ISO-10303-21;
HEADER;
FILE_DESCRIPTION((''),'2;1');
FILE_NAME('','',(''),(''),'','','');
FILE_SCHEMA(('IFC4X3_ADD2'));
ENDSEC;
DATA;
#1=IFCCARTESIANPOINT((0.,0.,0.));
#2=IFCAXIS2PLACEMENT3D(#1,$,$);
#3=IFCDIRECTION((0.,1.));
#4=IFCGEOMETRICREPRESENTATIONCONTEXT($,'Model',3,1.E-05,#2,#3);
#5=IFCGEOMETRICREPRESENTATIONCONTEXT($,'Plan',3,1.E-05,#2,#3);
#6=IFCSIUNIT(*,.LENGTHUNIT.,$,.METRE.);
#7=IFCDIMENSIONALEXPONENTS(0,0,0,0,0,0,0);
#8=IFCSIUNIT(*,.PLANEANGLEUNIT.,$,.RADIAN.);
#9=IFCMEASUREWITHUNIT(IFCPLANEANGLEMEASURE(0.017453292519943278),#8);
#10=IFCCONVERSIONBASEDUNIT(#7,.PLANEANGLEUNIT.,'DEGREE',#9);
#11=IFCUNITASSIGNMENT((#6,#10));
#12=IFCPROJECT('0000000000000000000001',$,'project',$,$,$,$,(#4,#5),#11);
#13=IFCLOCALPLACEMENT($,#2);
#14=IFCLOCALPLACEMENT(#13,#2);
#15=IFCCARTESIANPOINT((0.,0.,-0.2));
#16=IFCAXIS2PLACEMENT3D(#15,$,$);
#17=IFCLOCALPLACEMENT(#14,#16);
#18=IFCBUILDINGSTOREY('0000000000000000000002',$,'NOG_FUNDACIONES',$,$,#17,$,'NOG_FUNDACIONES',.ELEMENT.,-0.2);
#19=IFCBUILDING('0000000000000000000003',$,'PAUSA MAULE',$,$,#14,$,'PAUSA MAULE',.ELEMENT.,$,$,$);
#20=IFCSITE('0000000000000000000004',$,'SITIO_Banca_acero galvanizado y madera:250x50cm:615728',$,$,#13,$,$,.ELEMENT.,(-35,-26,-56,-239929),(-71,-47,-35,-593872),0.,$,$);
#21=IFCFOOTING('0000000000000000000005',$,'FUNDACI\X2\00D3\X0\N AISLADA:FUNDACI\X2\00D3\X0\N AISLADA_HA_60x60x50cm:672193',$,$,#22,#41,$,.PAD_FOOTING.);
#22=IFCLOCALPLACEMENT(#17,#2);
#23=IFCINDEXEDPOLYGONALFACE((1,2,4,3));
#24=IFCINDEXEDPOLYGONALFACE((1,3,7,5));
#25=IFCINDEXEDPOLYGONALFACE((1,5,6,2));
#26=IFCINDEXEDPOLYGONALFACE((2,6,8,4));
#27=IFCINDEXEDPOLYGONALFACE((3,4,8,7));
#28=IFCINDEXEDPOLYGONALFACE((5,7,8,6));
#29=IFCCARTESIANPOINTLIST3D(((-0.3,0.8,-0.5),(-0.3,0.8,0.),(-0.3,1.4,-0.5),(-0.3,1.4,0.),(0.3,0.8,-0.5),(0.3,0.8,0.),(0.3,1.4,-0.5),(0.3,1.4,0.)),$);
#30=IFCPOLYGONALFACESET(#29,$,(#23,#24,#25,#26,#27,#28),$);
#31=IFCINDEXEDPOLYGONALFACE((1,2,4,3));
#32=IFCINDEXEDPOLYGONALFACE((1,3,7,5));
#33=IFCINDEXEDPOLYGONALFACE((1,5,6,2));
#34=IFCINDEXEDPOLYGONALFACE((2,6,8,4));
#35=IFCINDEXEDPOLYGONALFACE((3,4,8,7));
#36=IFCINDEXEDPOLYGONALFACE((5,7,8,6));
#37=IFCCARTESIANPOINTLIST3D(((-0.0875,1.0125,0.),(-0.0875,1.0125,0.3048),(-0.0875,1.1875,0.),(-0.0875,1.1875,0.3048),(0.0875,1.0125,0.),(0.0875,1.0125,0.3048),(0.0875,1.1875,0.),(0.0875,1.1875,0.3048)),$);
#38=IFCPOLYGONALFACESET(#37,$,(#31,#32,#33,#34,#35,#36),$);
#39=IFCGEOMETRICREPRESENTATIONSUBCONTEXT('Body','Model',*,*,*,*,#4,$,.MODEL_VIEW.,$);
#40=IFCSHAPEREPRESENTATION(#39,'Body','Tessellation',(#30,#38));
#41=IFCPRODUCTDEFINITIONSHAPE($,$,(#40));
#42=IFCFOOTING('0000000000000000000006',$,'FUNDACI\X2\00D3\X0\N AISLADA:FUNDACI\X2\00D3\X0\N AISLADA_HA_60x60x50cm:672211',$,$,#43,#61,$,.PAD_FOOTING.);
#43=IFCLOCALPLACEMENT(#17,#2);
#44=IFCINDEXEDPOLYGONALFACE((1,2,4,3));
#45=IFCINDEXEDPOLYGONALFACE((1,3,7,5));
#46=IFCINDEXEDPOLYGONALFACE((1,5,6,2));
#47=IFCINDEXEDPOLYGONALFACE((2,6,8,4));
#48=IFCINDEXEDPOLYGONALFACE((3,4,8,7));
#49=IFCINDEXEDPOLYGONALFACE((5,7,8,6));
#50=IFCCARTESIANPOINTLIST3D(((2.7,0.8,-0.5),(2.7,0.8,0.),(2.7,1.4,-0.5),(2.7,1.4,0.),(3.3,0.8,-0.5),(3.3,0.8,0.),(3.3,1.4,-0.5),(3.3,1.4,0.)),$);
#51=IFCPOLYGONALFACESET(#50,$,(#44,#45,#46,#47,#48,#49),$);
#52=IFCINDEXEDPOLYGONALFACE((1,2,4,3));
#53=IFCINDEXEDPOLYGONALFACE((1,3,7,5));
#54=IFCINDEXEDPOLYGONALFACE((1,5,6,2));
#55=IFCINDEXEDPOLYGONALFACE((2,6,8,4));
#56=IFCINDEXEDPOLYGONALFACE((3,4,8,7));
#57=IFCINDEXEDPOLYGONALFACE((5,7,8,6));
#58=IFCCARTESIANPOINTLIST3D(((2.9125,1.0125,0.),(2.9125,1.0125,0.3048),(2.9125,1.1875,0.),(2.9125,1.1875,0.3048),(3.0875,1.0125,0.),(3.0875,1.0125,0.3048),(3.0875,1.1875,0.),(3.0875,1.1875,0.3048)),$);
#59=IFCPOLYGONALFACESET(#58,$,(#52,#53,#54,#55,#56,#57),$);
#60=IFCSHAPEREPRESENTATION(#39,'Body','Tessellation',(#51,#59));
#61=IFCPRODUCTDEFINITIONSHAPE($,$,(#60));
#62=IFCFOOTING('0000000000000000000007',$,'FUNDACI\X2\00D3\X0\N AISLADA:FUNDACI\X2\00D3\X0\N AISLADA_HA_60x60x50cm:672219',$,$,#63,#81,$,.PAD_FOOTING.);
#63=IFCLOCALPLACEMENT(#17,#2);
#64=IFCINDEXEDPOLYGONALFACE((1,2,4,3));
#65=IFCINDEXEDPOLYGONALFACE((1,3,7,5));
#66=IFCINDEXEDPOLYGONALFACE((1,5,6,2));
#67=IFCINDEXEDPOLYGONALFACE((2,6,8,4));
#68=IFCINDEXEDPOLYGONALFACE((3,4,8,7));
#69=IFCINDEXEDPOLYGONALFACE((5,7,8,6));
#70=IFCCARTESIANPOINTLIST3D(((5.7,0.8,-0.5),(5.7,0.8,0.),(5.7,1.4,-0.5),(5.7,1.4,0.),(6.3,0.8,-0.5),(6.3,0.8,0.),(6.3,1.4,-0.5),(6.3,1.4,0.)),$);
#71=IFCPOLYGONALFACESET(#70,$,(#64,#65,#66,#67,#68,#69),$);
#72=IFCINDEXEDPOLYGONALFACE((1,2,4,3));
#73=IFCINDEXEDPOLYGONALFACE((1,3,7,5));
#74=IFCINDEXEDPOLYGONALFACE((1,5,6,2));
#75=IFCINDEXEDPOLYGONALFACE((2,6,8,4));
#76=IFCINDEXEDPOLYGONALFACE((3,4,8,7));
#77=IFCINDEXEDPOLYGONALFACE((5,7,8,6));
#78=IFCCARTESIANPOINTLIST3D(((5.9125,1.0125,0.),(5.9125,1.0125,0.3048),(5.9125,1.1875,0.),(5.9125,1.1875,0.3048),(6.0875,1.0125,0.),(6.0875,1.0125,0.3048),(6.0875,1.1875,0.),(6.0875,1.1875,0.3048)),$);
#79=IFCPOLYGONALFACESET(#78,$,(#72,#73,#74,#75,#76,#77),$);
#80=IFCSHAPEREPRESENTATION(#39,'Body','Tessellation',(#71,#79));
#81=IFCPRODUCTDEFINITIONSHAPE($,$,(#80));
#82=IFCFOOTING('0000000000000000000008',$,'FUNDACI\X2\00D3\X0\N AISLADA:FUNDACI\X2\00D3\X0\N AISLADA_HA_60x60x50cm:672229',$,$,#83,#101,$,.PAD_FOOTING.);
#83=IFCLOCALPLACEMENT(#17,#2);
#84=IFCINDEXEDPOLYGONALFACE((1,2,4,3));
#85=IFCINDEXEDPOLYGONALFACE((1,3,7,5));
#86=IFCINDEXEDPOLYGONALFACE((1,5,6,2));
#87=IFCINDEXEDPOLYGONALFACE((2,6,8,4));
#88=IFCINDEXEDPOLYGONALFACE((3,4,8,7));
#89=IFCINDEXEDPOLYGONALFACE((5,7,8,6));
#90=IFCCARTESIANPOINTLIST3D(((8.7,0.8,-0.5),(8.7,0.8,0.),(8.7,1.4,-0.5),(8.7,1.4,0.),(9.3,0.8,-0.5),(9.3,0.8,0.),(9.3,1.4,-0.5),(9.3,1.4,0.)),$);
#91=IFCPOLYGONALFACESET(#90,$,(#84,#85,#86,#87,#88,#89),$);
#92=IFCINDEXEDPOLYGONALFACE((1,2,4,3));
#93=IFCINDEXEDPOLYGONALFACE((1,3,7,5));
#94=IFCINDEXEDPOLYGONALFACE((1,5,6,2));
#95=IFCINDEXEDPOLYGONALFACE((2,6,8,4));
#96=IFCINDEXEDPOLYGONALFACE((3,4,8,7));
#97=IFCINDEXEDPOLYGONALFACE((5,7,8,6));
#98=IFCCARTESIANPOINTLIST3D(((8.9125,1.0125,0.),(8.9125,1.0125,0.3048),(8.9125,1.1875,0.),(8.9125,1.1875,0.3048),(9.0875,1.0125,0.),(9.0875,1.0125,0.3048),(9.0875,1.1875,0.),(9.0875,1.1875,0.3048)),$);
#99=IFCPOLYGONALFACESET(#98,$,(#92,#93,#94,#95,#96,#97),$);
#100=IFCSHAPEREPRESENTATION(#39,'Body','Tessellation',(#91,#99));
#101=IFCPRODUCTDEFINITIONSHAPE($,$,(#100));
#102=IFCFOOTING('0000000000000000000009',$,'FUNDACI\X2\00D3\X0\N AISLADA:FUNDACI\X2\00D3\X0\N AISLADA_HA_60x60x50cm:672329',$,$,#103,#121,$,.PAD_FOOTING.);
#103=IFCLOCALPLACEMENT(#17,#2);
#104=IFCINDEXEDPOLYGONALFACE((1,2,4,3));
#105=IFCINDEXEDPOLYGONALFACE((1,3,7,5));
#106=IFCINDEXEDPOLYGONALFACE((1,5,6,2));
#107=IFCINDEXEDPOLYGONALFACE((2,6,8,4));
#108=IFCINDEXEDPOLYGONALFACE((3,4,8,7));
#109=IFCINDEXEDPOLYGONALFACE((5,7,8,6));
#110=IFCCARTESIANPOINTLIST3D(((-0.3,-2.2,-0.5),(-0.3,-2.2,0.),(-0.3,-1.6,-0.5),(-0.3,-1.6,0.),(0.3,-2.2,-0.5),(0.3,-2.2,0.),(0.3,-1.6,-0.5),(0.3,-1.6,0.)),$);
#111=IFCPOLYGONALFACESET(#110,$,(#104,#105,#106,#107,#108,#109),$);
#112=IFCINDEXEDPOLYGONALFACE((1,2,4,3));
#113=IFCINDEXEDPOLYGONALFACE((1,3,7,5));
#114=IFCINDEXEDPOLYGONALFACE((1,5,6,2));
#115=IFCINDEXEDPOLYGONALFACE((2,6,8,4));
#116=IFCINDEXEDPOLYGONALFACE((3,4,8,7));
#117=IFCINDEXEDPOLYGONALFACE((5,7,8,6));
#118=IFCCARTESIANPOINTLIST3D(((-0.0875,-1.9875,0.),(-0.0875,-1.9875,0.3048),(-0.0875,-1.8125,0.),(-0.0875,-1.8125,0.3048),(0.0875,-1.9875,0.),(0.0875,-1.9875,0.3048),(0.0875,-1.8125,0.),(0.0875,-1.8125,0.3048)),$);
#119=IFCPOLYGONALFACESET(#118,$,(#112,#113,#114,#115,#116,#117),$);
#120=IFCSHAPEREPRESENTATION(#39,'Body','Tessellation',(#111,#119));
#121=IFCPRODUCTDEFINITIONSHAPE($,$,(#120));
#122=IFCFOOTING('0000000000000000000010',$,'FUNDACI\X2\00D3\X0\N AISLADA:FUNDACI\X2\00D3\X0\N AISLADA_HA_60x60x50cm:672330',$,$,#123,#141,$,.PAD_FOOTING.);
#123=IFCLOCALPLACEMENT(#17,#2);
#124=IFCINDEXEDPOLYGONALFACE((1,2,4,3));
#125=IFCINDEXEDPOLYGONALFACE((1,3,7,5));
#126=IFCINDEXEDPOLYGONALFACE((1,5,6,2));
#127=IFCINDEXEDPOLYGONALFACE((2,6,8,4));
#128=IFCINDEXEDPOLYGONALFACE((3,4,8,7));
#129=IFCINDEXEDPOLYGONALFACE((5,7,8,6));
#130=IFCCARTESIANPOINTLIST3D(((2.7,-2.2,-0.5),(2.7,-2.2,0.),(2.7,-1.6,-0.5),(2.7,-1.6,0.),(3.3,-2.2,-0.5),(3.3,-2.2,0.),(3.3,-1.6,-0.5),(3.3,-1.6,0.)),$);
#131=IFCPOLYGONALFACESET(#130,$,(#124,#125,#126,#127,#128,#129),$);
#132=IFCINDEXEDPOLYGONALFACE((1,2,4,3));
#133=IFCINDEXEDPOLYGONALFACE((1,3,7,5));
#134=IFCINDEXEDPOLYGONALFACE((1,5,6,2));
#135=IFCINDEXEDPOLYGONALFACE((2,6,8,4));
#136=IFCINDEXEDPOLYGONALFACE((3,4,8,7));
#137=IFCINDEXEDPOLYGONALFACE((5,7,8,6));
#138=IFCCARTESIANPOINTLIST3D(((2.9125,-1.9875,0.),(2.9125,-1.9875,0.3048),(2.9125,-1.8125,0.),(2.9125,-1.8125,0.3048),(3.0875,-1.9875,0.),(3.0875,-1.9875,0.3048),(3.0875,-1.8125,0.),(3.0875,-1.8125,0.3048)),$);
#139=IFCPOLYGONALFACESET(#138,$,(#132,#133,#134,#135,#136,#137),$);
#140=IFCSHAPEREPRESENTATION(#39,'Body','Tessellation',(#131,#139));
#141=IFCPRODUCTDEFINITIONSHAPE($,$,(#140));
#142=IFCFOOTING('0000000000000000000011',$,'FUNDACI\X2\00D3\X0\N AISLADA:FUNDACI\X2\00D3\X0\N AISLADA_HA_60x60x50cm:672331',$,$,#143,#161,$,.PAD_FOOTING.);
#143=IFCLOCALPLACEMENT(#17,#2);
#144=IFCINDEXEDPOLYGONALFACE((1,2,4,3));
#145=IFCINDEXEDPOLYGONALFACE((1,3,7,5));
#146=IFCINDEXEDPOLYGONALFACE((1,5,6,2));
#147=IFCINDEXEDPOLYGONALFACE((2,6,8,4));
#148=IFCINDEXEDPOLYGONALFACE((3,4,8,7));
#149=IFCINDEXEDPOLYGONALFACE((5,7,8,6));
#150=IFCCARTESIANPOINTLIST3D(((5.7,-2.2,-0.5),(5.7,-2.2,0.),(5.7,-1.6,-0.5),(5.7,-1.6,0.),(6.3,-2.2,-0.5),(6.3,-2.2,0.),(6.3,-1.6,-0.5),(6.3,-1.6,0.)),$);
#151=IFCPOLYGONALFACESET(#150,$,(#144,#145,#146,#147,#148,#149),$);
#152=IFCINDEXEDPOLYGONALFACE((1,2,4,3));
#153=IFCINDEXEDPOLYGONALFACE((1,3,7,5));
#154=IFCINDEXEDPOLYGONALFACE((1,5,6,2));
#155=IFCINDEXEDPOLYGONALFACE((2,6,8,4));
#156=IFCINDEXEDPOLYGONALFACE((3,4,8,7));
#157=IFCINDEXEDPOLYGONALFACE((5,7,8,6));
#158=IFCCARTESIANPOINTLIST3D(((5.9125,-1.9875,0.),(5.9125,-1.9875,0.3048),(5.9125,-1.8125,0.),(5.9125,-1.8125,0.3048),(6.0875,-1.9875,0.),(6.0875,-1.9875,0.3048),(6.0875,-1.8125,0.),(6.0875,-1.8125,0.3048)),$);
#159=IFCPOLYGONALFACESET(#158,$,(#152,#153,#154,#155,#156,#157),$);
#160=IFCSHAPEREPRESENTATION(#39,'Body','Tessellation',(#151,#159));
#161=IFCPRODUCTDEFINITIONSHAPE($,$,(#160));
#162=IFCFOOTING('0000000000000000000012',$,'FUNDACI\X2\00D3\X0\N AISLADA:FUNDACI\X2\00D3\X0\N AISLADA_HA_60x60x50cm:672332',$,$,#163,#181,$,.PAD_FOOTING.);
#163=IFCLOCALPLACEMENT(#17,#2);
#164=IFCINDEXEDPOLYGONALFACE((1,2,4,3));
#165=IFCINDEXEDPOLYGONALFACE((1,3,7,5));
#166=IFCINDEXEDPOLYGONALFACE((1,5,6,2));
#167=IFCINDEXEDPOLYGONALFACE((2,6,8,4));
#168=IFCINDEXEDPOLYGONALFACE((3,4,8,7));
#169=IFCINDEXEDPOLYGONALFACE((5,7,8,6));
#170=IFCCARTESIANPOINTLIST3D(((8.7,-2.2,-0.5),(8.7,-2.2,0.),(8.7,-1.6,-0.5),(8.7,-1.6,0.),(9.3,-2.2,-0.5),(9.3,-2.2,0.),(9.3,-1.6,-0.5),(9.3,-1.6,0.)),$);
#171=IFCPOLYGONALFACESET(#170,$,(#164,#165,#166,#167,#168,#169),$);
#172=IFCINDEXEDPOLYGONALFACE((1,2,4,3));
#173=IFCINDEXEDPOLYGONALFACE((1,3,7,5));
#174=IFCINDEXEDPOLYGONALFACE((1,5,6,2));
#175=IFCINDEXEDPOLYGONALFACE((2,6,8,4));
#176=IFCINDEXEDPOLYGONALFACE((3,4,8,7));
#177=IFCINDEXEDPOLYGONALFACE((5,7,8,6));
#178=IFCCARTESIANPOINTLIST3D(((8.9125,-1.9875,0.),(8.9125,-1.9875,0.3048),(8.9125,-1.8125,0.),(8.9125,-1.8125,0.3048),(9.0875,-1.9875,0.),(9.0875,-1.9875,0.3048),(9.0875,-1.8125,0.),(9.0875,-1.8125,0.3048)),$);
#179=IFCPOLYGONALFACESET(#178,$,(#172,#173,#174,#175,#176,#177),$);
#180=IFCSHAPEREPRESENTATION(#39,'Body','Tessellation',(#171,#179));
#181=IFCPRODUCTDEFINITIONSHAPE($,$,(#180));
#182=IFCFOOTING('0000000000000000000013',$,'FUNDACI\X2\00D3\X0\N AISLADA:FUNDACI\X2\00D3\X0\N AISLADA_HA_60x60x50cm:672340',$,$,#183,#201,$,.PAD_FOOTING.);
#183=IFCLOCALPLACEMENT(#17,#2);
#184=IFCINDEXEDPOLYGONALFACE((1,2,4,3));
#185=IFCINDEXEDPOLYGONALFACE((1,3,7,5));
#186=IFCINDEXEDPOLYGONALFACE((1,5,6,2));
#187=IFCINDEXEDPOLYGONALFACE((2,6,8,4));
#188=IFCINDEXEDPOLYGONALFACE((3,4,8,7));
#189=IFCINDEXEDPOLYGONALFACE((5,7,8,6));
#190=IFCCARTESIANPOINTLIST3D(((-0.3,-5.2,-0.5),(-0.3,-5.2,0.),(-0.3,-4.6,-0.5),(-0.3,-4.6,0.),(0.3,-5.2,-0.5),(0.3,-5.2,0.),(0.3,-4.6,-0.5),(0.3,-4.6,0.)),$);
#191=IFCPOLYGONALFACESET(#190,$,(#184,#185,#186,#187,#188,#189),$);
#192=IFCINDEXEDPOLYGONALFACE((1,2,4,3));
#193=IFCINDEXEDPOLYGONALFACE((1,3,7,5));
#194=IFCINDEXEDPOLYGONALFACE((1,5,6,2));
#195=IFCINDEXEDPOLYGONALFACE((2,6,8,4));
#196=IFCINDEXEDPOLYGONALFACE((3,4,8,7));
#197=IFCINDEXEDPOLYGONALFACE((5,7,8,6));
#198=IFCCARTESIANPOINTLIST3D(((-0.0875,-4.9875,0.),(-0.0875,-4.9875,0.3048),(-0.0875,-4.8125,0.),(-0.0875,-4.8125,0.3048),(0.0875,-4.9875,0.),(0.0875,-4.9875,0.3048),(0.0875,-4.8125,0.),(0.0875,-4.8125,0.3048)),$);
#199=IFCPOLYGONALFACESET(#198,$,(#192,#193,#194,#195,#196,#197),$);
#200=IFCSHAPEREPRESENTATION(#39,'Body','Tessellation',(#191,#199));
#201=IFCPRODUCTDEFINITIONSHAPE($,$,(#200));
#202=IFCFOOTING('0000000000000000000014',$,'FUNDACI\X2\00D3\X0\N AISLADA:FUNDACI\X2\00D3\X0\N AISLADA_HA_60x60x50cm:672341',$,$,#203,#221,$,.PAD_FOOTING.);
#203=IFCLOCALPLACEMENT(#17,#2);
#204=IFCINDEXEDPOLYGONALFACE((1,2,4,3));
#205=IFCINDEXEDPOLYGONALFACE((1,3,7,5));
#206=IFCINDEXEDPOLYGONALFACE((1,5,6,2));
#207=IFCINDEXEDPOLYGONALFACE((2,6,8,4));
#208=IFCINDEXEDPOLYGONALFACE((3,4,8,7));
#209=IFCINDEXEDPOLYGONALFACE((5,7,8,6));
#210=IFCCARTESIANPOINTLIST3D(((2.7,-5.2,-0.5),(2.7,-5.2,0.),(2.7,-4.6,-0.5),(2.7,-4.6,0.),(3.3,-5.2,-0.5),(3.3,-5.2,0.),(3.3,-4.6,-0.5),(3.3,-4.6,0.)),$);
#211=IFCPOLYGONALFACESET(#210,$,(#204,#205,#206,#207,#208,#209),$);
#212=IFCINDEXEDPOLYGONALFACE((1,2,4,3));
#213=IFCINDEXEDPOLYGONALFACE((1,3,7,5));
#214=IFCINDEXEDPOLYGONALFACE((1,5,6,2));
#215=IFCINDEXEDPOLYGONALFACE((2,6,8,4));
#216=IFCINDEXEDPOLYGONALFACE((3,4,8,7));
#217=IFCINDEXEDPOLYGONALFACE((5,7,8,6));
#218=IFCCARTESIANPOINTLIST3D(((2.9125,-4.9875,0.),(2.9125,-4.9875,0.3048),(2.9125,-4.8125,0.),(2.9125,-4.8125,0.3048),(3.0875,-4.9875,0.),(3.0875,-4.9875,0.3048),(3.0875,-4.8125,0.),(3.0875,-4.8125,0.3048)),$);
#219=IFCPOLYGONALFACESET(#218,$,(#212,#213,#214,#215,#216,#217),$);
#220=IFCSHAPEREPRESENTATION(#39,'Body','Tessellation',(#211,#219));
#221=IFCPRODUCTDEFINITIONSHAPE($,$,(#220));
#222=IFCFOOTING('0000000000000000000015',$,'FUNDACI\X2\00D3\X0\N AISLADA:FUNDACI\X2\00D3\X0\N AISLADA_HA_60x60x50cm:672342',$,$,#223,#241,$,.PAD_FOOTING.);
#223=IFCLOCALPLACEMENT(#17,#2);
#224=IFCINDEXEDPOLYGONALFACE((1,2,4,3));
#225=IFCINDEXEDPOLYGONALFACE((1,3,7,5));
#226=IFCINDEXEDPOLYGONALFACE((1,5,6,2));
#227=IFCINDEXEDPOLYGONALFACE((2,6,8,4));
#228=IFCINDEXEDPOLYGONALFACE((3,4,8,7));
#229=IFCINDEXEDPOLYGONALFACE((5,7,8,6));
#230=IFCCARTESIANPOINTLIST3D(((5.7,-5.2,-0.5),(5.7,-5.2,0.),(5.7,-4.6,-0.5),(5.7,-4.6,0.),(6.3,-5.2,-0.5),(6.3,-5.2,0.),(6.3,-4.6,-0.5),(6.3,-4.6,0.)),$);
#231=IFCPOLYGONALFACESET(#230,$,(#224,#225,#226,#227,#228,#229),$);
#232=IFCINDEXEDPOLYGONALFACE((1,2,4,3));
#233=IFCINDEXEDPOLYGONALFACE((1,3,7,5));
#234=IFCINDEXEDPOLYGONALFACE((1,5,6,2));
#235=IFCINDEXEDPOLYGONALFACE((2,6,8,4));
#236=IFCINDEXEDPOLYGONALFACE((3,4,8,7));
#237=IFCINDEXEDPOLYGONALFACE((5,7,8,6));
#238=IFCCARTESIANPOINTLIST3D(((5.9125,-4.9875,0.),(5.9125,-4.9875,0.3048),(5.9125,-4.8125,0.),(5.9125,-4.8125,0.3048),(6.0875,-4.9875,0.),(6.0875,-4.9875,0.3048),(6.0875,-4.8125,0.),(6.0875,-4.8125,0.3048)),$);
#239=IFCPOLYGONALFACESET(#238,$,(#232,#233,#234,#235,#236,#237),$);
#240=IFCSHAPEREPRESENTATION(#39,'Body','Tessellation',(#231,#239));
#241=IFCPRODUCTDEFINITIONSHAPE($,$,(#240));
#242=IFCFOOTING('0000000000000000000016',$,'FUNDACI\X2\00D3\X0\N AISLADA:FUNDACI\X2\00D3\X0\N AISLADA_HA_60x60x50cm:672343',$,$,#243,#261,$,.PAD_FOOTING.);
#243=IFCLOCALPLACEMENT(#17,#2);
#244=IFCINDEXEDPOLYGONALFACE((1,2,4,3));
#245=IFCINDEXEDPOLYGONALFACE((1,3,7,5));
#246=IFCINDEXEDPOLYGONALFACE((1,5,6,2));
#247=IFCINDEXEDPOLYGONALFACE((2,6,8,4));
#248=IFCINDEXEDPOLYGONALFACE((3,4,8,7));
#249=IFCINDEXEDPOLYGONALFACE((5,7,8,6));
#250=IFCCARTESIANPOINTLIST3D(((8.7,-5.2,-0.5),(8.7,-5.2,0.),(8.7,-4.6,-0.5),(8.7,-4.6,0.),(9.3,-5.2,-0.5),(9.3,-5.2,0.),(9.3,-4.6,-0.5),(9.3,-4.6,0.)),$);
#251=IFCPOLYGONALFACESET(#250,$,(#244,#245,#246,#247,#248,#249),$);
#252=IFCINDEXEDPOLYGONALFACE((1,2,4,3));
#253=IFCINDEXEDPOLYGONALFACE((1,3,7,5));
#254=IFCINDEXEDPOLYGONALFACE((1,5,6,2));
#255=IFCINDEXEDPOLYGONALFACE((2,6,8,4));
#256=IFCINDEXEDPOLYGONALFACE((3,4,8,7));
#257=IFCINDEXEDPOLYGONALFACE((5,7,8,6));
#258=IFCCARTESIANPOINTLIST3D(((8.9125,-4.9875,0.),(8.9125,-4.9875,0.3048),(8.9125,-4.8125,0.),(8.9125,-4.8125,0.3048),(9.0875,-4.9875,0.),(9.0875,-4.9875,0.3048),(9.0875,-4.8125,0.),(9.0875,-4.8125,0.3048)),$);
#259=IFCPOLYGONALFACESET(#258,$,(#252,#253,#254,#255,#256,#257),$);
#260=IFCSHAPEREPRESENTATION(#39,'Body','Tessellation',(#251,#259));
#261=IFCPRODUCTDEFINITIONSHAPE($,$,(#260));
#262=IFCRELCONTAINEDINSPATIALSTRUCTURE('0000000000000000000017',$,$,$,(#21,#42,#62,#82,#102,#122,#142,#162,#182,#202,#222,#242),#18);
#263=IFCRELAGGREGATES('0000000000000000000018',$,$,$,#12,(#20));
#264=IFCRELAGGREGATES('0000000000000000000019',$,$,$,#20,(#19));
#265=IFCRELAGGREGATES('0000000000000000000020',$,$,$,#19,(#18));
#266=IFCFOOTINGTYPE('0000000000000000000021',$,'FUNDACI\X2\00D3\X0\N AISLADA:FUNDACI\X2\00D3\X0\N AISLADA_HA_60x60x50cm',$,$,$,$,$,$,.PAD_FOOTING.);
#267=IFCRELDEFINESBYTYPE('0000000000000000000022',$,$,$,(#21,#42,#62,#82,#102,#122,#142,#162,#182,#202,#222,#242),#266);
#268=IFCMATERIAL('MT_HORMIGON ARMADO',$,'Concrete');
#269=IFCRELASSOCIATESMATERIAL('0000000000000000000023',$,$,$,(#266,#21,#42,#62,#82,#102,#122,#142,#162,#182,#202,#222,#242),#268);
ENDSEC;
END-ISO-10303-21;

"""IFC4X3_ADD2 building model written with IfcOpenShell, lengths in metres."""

from ifc_helpers import new_model, entity, si_unit, converted_unit, direction, frame, origin, origin_2d_with_axis, place, context, subcontext, project, spatial, rectangle, extrude, source, transform, mapped, material, type_object, type_shapes, element, save


model = new_model("IFC4X3_ADD2")

# Units and contexts
model_context = context("Model", 3, precision=1e-05, world=origin(), true_north=direction((0.0, 1.0)))
plan_context = context("Plan", 3, precision=1e-05, world=origin(), true_north=direction((0.0, 1.0)))
body_context = subcontext(model_context, "Body", "Model", "MODEL_VIEW")
ifc_project = project(units=[si_unit("LENGTHUNIT", "METRE"), converted_unit("PLANEANGLEUNIT", "DEGREE", entity("IfcPlaneAngleMeasure", 0.017453292519943278), si_unit("PLANEANGLEUNIT", "RADIAN"), dimensions=[0, 0, 0, 0, 0, 0, 0])], contexts=[model_context, plan_context])

# Site, building, storey
site_placement = place(None, origin())
site = spatial("IfcSite", under=ifc_project, at=site_placement, Name="SITIO_Banca_acero galvanizado y madera:250x50cm:615728", CompositionType="ELEMENT", RefLatitude=(-35, -26, -56, -239929), RefLongitude=(-71, -47, -35, -593872), RefElevation=0.0)
building_placement = place(site_placement, origin())
building = spatial("IfcBuilding", under=site, at=building_placement, Name="PAUSA MAULE", LongName="PAUSA MAULE", CompositionType="ELEMENT")
storey_placement = place(building_placement, frame((0.0, 0.0, -0.2)))
storey = spatial("IfcBuildingStorey", under=building, at=storey_placement, Name="NOG_FUNDACIONES", LongName="NOG_FUNDACIONES", CompositionType="ELEMENT", Elevation=-0.2)

# Footings
ifc_material = material(Name="MT_HORMIGON ARMADO", Category="Concrete")
footing_type = type_object("IfcFootingType", Name="FUNDACIÓN AISLADA:FUNDACIÓN AISLADA_HA_60x60x50cm", PredefinedType="PAD_FOOTING", material=ifc_material)
shared_shape = source(origin(), body_context, "Body", "SweptSolid", [
    extrude(rectangle(XDim=0.6, YDim=0.6, at=origin_2d_with_axis()), frame((0.0, 0.0, -0.5), z_axis=(0.0, 0.0, 1.0), x_axis=(-1.0, 0.0, 0.0)), (0.0, 0.0, 1.0), 0.5),
    extrude(rectangle(XDim=0.175, YDim=0.175, at=origin_2d_with_axis()), frame((0.0, 0.0, 0.0), z_axis=(0.0, 0.0, 1.0), x_axis=(-1.0, 0.0, 0.0)), (0.0, 0.0, 1.0), 0.3048),
])
type_shapes(footing_type, [shared_shape])
for number, where, name in (
    (1, (0.0, 1.1, 0.0), "FUNDACIÓN AISLADA:FUNDACIÓN AISLADA_HA_60x60x50cm:672193"),
    (2, (3.0, 1.1, 0.0), "FUNDACIÓN AISLADA:FUNDACIÓN AISLADA_HA_60x60x50cm:672211"),
    (3, (6.0, 1.1, 0.0), "FUNDACIÓN AISLADA:FUNDACIÓN AISLADA_HA_60x60x50cm:672219"),
    (4, (9.0, 1.1, 0.0), "FUNDACIÓN AISLADA:FUNDACIÓN AISLADA_HA_60x60x50cm:672229"),
    (5, (0.0, -1.9, 0.0), "FUNDACIÓN AISLADA:FUNDACIÓN AISLADA_HA_60x60x50cm:672329"),
    (6, (3.0, -1.9, 0.0), "FUNDACIÓN AISLADA:FUNDACIÓN AISLADA_HA_60x60x50cm:672330"),
    (7, (6.0, -1.9, 0.0), "FUNDACIÓN AISLADA:FUNDACIÓN AISLADA_HA_60x60x50cm:672331"),
    (8, (9.0, -1.9, 0.0), "FUNDACIÓN AISLADA:FUNDACIÓN AISLADA_HA_60x60x50cm:672332"),
    (9, (0.0, -4.9, 0.0), "FUNDACIÓN AISLADA:FUNDACIÓN AISLADA_HA_60x60x50cm:672340"),
    (10, (3.0, -4.9, 0.0), "FUNDACIÓN AISLADA:FUNDACIÓN AISLADA_HA_60x60x50cm:672341"),
    (11, (6.0, -4.9, 0.0), "FUNDACIÓN AISLADA:FUNDACIÓN AISLADA_HA_60x60x50cm:672342"),
    (12, (9.0, -4.9, 0.0), "FUNDACIÓN AISLADA:FUNDACIÓN AISLADA_HA_60x60x50cm:672343"),
):
    element("IfcFooting", number, at=place(storey_placement, frame(where)), inside=storey, type_object=footing_type, material=ifc_material, Name=name, PredefinedType="PAD_FOOTING", context=body_context, shape_type="MappedRepresentation", body=[
        mapped(shared_shape, transform((0.0, 0.0, 0.0), scale=1.0)),
    ])

save(model, "model.ifc")
